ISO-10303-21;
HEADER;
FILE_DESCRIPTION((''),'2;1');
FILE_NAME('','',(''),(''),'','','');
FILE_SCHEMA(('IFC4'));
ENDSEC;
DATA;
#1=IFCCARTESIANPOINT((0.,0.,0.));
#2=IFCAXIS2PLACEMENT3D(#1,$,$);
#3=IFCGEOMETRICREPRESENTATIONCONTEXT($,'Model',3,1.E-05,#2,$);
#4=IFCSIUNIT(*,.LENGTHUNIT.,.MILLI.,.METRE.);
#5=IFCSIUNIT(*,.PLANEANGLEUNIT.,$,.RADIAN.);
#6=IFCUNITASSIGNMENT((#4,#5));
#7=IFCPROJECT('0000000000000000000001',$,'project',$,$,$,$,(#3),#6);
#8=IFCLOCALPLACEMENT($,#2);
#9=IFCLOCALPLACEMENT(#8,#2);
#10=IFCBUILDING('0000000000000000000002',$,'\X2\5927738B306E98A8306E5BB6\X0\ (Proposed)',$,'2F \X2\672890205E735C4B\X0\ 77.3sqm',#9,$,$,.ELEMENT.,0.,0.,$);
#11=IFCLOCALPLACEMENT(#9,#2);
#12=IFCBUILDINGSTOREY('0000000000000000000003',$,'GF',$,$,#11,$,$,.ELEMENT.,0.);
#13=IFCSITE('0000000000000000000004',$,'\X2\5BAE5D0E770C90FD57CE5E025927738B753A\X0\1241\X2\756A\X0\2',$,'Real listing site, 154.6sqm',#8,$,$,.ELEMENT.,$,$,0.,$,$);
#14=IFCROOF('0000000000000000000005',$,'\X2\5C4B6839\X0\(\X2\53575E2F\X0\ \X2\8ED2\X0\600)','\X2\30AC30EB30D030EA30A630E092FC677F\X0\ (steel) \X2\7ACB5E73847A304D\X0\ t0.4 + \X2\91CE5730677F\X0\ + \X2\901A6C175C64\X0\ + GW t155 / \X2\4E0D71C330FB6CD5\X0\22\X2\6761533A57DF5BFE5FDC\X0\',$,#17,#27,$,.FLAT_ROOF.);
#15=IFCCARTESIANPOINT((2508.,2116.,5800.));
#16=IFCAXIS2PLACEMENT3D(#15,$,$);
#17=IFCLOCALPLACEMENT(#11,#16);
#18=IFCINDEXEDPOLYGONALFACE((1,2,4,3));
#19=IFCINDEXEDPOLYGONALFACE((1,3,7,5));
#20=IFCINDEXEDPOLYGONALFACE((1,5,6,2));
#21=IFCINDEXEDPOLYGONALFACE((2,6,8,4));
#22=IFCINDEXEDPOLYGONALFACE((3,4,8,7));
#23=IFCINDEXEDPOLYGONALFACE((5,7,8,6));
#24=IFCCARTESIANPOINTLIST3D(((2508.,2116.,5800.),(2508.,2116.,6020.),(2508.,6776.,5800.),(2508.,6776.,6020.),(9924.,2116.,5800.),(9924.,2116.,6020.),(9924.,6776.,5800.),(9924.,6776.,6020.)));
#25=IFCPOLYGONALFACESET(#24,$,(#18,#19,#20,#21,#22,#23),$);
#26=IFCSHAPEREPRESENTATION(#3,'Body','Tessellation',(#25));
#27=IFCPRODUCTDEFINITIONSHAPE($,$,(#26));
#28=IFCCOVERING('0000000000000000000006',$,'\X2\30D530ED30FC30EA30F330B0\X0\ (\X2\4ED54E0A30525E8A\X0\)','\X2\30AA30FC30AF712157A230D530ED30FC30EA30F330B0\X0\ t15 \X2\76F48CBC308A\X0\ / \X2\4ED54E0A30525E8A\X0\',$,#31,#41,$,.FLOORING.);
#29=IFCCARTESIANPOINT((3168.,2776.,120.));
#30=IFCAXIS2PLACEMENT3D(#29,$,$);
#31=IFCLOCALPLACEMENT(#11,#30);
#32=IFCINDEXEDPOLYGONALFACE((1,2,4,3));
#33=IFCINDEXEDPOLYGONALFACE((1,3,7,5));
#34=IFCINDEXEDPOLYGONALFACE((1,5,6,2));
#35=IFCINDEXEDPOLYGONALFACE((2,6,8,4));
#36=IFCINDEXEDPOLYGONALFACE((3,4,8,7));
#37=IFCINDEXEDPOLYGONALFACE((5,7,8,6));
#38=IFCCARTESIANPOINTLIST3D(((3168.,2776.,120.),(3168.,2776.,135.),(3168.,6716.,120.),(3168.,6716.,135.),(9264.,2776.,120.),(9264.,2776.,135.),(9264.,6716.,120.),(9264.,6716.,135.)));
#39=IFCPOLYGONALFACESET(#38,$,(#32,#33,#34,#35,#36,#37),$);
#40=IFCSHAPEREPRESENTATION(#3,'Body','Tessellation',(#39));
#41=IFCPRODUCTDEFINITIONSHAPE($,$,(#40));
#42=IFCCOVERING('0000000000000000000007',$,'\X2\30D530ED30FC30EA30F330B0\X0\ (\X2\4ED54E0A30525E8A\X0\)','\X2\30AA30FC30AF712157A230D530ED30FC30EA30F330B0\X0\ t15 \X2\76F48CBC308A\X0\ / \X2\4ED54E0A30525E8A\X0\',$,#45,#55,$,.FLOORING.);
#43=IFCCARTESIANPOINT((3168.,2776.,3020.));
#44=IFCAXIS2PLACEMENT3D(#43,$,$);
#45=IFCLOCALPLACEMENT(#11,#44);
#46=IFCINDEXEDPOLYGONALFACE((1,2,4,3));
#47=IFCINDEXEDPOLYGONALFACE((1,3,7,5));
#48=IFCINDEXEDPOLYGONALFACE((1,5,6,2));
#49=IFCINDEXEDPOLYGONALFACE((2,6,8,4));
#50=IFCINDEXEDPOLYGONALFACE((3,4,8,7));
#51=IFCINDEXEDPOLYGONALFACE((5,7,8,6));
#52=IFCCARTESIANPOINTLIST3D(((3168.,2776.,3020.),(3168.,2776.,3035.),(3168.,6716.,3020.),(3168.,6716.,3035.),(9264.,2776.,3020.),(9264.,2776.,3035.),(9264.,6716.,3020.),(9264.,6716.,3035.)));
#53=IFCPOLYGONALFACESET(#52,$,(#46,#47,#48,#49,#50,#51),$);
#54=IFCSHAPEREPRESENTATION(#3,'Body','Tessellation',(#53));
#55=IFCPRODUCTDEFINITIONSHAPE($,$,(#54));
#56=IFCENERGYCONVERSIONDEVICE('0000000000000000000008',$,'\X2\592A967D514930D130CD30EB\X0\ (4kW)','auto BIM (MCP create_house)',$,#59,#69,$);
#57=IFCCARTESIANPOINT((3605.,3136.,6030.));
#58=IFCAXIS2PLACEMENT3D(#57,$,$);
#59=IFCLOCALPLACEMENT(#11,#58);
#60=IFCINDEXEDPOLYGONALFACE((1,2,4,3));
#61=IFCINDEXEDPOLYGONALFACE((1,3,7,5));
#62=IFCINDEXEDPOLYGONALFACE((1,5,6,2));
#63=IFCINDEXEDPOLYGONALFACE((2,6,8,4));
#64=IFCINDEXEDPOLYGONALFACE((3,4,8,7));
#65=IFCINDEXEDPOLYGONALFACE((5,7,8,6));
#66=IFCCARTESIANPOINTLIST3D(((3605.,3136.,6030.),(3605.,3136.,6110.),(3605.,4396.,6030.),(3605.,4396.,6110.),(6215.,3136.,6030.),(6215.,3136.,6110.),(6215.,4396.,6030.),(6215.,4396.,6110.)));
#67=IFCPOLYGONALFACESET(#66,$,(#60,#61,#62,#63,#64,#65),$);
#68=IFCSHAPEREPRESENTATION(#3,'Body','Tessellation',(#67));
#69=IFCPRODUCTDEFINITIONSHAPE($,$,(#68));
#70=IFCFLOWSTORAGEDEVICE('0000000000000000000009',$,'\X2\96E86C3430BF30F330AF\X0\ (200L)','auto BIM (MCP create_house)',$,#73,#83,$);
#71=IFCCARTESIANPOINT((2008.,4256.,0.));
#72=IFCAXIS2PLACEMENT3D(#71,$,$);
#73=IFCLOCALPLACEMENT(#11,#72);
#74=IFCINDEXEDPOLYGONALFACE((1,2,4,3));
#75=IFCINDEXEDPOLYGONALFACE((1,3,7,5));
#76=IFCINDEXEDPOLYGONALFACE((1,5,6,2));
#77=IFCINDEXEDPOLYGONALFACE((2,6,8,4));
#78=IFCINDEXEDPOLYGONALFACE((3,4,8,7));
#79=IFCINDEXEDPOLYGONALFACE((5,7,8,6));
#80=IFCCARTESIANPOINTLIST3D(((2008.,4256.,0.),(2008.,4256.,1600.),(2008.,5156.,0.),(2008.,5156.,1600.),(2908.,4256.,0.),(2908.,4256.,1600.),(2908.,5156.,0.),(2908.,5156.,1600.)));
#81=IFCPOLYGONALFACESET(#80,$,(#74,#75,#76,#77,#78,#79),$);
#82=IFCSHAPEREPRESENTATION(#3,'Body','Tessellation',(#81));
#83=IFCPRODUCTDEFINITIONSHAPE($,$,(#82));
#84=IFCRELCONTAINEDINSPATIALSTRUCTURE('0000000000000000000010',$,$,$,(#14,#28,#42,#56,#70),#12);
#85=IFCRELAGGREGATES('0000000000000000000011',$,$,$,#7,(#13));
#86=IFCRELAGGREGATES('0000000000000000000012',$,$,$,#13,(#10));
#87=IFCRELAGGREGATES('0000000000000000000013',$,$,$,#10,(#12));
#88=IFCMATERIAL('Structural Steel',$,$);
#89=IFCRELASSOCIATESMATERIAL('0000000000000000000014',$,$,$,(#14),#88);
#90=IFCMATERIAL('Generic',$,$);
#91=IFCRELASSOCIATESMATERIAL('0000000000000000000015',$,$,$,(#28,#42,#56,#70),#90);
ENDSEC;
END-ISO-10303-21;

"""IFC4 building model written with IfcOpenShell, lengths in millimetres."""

from ifc_helpers import new_model, si_unit, frame, frame_2d, origin, place, context, project, spatial, rectangle, extrude, material, element, save


model = new_model("IFC4")

# Units and contexts
model_context = context("Model", 3, precision=1e-05, world=origin())
ifc_project = project(units=[si_unit("LENGTHUNIT", "METRE", prefix="MILLI"), si_unit("PLANEANGLEUNIT", "RADIAN")], contexts=[model_context])

# Site, building, storey
site_placement = place(None, origin())
site = spatial("IfcSite", under=ifc_project, at=site_placement, Name="宮崎県都城市大王町1241番2", ObjectType="Real listing site, 154.6sqm", CompositionType="ELEMENT", RefElevation=0.0)
building_placement = place(site_placement, origin())
building = spatial("IfcBuilding", under=site, at=building_placement, Name="大王の風の家 (Proposed)", ObjectType="2F 木造平屋 77.3sqm", CompositionType="ELEMENT", ElevationOfRefHeight=0.0, ElevationOfTerrain=0.0)
storey_placement = place(building_placement, origin())
storey = spatial("IfcBuildingStorey", under=building, at=storey_placement, Name="GF", CompositionType="ELEMENT", Elevation=0.0)

# Roof
ifc_material_1 = material(Name="Structural Steel")
for number, where, name in (
    (1, (2508.0, 2116.0, 5800.0), "屋根(南帯 軒600)"),
):
    element("IfcRoof", number, at=place(storey_placement, frame(where)), inside=storey, material=ifc_material_1, Name=name, Description="ガルバリウム鋼板 (steel) 立平葺き t0.4 + 野地板 + 通気層 + GW t155 / 不燃・法22条区域対応", PredefinedType="FLAT_ROOF", context=model_context, shape_type="SweptSolid", body=[
        extrude(rectangle(XDim=7416.0, YDim=4660.0, at=frame_2d((3708.0, 2330.0))), frame((2508.0, 2116.0, 5800.0)), (0.0, 0.0, 1.0), 220.0),
    ])

# Coverings
ifc_material_2 = material(Name="Generic")
covering_1_placement = place(storey_placement, frame((3168.0, 2776.0, 120.0)))
element("IfcCovering", 2, at=covering_1_placement, inside=storey, material=ifc_material_2, Name="フローリング (仕上げ床)", Description="オーク無垢フローリング t15 直貼り / 仕上げ床", PredefinedType="FLOORING", context=model_context, shape_type="SweptSolid", body=[
    extrude(rectangle(XDim=6096.0, YDim=3940.0, at=frame_2d((3048.0, 1970.0))), frame((3168.0, 2776.0, 120.0)), (0.0, 0.0, 1.0), 15.0),
])
covering_2_placement = place(storey_placement, frame((3168.0, 2776.0, 3020.0)))
element("IfcCovering", 3, at=covering_2_placement, inside=storey, material=ifc_material_2, Name="フローリング (仕上げ床)", Description="オーク無垢フローリング t15 直貼り / 仕上げ床", PredefinedType="FLOORING", context=model_context, shape_type="SweptSolid", body=[
    extrude(rectangle(XDim=6096.0, YDim=3940.0, at=frame_2d((3048.0, 1970.0))), frame((3168.0, 2776.0, 3020.0)), (0.0, 0.0, 1.0), 15.0),
])

# Energy conversion device
energy_conversion_device_placement = place(storey_placement, frame((3605.0, 3136.0, 6030.0)))
element("IfcEnergyConversionDevice", 4, at=energy_conversion_device_placement, inside=storey, material=ifc_material_2, Name="太陽光パネル (4kW)", Description="auto BIM (MCP create_house)", context=model_context, shape_type="SweptSolid", body=[
    extrude(rectangle(XDim=2610.0, YDim=1260.0, at=frame_2d((1305.0, 630.0))), frame((3605.0, 3136.0, 6030.0)), (0.0, 0.0, 1.0), 80.0),
])

# Flow storage device
flow_storage_device_placement = place(storey_placement, frame((2008.0, 4256.0, 0.0)))
element("IfcFlowStorageDevice", 5, at=flow_storage_device_placement, inside=storey, material=ifc_material_2, Name="雨水タンク (200L)", Description="auto BIM (MCP create_house)", context=model_context, shape_type="SweptSolid", body=[
    extrude(rectangle(XDim=900.0, YDim=900.0, at=frame_2d((450.0, 450.0))), frame((2008.0, 4256.0, 0.0)), (0.0, 0.0, 1.0), 1600.0),
])

save(model, "model.ifc")
